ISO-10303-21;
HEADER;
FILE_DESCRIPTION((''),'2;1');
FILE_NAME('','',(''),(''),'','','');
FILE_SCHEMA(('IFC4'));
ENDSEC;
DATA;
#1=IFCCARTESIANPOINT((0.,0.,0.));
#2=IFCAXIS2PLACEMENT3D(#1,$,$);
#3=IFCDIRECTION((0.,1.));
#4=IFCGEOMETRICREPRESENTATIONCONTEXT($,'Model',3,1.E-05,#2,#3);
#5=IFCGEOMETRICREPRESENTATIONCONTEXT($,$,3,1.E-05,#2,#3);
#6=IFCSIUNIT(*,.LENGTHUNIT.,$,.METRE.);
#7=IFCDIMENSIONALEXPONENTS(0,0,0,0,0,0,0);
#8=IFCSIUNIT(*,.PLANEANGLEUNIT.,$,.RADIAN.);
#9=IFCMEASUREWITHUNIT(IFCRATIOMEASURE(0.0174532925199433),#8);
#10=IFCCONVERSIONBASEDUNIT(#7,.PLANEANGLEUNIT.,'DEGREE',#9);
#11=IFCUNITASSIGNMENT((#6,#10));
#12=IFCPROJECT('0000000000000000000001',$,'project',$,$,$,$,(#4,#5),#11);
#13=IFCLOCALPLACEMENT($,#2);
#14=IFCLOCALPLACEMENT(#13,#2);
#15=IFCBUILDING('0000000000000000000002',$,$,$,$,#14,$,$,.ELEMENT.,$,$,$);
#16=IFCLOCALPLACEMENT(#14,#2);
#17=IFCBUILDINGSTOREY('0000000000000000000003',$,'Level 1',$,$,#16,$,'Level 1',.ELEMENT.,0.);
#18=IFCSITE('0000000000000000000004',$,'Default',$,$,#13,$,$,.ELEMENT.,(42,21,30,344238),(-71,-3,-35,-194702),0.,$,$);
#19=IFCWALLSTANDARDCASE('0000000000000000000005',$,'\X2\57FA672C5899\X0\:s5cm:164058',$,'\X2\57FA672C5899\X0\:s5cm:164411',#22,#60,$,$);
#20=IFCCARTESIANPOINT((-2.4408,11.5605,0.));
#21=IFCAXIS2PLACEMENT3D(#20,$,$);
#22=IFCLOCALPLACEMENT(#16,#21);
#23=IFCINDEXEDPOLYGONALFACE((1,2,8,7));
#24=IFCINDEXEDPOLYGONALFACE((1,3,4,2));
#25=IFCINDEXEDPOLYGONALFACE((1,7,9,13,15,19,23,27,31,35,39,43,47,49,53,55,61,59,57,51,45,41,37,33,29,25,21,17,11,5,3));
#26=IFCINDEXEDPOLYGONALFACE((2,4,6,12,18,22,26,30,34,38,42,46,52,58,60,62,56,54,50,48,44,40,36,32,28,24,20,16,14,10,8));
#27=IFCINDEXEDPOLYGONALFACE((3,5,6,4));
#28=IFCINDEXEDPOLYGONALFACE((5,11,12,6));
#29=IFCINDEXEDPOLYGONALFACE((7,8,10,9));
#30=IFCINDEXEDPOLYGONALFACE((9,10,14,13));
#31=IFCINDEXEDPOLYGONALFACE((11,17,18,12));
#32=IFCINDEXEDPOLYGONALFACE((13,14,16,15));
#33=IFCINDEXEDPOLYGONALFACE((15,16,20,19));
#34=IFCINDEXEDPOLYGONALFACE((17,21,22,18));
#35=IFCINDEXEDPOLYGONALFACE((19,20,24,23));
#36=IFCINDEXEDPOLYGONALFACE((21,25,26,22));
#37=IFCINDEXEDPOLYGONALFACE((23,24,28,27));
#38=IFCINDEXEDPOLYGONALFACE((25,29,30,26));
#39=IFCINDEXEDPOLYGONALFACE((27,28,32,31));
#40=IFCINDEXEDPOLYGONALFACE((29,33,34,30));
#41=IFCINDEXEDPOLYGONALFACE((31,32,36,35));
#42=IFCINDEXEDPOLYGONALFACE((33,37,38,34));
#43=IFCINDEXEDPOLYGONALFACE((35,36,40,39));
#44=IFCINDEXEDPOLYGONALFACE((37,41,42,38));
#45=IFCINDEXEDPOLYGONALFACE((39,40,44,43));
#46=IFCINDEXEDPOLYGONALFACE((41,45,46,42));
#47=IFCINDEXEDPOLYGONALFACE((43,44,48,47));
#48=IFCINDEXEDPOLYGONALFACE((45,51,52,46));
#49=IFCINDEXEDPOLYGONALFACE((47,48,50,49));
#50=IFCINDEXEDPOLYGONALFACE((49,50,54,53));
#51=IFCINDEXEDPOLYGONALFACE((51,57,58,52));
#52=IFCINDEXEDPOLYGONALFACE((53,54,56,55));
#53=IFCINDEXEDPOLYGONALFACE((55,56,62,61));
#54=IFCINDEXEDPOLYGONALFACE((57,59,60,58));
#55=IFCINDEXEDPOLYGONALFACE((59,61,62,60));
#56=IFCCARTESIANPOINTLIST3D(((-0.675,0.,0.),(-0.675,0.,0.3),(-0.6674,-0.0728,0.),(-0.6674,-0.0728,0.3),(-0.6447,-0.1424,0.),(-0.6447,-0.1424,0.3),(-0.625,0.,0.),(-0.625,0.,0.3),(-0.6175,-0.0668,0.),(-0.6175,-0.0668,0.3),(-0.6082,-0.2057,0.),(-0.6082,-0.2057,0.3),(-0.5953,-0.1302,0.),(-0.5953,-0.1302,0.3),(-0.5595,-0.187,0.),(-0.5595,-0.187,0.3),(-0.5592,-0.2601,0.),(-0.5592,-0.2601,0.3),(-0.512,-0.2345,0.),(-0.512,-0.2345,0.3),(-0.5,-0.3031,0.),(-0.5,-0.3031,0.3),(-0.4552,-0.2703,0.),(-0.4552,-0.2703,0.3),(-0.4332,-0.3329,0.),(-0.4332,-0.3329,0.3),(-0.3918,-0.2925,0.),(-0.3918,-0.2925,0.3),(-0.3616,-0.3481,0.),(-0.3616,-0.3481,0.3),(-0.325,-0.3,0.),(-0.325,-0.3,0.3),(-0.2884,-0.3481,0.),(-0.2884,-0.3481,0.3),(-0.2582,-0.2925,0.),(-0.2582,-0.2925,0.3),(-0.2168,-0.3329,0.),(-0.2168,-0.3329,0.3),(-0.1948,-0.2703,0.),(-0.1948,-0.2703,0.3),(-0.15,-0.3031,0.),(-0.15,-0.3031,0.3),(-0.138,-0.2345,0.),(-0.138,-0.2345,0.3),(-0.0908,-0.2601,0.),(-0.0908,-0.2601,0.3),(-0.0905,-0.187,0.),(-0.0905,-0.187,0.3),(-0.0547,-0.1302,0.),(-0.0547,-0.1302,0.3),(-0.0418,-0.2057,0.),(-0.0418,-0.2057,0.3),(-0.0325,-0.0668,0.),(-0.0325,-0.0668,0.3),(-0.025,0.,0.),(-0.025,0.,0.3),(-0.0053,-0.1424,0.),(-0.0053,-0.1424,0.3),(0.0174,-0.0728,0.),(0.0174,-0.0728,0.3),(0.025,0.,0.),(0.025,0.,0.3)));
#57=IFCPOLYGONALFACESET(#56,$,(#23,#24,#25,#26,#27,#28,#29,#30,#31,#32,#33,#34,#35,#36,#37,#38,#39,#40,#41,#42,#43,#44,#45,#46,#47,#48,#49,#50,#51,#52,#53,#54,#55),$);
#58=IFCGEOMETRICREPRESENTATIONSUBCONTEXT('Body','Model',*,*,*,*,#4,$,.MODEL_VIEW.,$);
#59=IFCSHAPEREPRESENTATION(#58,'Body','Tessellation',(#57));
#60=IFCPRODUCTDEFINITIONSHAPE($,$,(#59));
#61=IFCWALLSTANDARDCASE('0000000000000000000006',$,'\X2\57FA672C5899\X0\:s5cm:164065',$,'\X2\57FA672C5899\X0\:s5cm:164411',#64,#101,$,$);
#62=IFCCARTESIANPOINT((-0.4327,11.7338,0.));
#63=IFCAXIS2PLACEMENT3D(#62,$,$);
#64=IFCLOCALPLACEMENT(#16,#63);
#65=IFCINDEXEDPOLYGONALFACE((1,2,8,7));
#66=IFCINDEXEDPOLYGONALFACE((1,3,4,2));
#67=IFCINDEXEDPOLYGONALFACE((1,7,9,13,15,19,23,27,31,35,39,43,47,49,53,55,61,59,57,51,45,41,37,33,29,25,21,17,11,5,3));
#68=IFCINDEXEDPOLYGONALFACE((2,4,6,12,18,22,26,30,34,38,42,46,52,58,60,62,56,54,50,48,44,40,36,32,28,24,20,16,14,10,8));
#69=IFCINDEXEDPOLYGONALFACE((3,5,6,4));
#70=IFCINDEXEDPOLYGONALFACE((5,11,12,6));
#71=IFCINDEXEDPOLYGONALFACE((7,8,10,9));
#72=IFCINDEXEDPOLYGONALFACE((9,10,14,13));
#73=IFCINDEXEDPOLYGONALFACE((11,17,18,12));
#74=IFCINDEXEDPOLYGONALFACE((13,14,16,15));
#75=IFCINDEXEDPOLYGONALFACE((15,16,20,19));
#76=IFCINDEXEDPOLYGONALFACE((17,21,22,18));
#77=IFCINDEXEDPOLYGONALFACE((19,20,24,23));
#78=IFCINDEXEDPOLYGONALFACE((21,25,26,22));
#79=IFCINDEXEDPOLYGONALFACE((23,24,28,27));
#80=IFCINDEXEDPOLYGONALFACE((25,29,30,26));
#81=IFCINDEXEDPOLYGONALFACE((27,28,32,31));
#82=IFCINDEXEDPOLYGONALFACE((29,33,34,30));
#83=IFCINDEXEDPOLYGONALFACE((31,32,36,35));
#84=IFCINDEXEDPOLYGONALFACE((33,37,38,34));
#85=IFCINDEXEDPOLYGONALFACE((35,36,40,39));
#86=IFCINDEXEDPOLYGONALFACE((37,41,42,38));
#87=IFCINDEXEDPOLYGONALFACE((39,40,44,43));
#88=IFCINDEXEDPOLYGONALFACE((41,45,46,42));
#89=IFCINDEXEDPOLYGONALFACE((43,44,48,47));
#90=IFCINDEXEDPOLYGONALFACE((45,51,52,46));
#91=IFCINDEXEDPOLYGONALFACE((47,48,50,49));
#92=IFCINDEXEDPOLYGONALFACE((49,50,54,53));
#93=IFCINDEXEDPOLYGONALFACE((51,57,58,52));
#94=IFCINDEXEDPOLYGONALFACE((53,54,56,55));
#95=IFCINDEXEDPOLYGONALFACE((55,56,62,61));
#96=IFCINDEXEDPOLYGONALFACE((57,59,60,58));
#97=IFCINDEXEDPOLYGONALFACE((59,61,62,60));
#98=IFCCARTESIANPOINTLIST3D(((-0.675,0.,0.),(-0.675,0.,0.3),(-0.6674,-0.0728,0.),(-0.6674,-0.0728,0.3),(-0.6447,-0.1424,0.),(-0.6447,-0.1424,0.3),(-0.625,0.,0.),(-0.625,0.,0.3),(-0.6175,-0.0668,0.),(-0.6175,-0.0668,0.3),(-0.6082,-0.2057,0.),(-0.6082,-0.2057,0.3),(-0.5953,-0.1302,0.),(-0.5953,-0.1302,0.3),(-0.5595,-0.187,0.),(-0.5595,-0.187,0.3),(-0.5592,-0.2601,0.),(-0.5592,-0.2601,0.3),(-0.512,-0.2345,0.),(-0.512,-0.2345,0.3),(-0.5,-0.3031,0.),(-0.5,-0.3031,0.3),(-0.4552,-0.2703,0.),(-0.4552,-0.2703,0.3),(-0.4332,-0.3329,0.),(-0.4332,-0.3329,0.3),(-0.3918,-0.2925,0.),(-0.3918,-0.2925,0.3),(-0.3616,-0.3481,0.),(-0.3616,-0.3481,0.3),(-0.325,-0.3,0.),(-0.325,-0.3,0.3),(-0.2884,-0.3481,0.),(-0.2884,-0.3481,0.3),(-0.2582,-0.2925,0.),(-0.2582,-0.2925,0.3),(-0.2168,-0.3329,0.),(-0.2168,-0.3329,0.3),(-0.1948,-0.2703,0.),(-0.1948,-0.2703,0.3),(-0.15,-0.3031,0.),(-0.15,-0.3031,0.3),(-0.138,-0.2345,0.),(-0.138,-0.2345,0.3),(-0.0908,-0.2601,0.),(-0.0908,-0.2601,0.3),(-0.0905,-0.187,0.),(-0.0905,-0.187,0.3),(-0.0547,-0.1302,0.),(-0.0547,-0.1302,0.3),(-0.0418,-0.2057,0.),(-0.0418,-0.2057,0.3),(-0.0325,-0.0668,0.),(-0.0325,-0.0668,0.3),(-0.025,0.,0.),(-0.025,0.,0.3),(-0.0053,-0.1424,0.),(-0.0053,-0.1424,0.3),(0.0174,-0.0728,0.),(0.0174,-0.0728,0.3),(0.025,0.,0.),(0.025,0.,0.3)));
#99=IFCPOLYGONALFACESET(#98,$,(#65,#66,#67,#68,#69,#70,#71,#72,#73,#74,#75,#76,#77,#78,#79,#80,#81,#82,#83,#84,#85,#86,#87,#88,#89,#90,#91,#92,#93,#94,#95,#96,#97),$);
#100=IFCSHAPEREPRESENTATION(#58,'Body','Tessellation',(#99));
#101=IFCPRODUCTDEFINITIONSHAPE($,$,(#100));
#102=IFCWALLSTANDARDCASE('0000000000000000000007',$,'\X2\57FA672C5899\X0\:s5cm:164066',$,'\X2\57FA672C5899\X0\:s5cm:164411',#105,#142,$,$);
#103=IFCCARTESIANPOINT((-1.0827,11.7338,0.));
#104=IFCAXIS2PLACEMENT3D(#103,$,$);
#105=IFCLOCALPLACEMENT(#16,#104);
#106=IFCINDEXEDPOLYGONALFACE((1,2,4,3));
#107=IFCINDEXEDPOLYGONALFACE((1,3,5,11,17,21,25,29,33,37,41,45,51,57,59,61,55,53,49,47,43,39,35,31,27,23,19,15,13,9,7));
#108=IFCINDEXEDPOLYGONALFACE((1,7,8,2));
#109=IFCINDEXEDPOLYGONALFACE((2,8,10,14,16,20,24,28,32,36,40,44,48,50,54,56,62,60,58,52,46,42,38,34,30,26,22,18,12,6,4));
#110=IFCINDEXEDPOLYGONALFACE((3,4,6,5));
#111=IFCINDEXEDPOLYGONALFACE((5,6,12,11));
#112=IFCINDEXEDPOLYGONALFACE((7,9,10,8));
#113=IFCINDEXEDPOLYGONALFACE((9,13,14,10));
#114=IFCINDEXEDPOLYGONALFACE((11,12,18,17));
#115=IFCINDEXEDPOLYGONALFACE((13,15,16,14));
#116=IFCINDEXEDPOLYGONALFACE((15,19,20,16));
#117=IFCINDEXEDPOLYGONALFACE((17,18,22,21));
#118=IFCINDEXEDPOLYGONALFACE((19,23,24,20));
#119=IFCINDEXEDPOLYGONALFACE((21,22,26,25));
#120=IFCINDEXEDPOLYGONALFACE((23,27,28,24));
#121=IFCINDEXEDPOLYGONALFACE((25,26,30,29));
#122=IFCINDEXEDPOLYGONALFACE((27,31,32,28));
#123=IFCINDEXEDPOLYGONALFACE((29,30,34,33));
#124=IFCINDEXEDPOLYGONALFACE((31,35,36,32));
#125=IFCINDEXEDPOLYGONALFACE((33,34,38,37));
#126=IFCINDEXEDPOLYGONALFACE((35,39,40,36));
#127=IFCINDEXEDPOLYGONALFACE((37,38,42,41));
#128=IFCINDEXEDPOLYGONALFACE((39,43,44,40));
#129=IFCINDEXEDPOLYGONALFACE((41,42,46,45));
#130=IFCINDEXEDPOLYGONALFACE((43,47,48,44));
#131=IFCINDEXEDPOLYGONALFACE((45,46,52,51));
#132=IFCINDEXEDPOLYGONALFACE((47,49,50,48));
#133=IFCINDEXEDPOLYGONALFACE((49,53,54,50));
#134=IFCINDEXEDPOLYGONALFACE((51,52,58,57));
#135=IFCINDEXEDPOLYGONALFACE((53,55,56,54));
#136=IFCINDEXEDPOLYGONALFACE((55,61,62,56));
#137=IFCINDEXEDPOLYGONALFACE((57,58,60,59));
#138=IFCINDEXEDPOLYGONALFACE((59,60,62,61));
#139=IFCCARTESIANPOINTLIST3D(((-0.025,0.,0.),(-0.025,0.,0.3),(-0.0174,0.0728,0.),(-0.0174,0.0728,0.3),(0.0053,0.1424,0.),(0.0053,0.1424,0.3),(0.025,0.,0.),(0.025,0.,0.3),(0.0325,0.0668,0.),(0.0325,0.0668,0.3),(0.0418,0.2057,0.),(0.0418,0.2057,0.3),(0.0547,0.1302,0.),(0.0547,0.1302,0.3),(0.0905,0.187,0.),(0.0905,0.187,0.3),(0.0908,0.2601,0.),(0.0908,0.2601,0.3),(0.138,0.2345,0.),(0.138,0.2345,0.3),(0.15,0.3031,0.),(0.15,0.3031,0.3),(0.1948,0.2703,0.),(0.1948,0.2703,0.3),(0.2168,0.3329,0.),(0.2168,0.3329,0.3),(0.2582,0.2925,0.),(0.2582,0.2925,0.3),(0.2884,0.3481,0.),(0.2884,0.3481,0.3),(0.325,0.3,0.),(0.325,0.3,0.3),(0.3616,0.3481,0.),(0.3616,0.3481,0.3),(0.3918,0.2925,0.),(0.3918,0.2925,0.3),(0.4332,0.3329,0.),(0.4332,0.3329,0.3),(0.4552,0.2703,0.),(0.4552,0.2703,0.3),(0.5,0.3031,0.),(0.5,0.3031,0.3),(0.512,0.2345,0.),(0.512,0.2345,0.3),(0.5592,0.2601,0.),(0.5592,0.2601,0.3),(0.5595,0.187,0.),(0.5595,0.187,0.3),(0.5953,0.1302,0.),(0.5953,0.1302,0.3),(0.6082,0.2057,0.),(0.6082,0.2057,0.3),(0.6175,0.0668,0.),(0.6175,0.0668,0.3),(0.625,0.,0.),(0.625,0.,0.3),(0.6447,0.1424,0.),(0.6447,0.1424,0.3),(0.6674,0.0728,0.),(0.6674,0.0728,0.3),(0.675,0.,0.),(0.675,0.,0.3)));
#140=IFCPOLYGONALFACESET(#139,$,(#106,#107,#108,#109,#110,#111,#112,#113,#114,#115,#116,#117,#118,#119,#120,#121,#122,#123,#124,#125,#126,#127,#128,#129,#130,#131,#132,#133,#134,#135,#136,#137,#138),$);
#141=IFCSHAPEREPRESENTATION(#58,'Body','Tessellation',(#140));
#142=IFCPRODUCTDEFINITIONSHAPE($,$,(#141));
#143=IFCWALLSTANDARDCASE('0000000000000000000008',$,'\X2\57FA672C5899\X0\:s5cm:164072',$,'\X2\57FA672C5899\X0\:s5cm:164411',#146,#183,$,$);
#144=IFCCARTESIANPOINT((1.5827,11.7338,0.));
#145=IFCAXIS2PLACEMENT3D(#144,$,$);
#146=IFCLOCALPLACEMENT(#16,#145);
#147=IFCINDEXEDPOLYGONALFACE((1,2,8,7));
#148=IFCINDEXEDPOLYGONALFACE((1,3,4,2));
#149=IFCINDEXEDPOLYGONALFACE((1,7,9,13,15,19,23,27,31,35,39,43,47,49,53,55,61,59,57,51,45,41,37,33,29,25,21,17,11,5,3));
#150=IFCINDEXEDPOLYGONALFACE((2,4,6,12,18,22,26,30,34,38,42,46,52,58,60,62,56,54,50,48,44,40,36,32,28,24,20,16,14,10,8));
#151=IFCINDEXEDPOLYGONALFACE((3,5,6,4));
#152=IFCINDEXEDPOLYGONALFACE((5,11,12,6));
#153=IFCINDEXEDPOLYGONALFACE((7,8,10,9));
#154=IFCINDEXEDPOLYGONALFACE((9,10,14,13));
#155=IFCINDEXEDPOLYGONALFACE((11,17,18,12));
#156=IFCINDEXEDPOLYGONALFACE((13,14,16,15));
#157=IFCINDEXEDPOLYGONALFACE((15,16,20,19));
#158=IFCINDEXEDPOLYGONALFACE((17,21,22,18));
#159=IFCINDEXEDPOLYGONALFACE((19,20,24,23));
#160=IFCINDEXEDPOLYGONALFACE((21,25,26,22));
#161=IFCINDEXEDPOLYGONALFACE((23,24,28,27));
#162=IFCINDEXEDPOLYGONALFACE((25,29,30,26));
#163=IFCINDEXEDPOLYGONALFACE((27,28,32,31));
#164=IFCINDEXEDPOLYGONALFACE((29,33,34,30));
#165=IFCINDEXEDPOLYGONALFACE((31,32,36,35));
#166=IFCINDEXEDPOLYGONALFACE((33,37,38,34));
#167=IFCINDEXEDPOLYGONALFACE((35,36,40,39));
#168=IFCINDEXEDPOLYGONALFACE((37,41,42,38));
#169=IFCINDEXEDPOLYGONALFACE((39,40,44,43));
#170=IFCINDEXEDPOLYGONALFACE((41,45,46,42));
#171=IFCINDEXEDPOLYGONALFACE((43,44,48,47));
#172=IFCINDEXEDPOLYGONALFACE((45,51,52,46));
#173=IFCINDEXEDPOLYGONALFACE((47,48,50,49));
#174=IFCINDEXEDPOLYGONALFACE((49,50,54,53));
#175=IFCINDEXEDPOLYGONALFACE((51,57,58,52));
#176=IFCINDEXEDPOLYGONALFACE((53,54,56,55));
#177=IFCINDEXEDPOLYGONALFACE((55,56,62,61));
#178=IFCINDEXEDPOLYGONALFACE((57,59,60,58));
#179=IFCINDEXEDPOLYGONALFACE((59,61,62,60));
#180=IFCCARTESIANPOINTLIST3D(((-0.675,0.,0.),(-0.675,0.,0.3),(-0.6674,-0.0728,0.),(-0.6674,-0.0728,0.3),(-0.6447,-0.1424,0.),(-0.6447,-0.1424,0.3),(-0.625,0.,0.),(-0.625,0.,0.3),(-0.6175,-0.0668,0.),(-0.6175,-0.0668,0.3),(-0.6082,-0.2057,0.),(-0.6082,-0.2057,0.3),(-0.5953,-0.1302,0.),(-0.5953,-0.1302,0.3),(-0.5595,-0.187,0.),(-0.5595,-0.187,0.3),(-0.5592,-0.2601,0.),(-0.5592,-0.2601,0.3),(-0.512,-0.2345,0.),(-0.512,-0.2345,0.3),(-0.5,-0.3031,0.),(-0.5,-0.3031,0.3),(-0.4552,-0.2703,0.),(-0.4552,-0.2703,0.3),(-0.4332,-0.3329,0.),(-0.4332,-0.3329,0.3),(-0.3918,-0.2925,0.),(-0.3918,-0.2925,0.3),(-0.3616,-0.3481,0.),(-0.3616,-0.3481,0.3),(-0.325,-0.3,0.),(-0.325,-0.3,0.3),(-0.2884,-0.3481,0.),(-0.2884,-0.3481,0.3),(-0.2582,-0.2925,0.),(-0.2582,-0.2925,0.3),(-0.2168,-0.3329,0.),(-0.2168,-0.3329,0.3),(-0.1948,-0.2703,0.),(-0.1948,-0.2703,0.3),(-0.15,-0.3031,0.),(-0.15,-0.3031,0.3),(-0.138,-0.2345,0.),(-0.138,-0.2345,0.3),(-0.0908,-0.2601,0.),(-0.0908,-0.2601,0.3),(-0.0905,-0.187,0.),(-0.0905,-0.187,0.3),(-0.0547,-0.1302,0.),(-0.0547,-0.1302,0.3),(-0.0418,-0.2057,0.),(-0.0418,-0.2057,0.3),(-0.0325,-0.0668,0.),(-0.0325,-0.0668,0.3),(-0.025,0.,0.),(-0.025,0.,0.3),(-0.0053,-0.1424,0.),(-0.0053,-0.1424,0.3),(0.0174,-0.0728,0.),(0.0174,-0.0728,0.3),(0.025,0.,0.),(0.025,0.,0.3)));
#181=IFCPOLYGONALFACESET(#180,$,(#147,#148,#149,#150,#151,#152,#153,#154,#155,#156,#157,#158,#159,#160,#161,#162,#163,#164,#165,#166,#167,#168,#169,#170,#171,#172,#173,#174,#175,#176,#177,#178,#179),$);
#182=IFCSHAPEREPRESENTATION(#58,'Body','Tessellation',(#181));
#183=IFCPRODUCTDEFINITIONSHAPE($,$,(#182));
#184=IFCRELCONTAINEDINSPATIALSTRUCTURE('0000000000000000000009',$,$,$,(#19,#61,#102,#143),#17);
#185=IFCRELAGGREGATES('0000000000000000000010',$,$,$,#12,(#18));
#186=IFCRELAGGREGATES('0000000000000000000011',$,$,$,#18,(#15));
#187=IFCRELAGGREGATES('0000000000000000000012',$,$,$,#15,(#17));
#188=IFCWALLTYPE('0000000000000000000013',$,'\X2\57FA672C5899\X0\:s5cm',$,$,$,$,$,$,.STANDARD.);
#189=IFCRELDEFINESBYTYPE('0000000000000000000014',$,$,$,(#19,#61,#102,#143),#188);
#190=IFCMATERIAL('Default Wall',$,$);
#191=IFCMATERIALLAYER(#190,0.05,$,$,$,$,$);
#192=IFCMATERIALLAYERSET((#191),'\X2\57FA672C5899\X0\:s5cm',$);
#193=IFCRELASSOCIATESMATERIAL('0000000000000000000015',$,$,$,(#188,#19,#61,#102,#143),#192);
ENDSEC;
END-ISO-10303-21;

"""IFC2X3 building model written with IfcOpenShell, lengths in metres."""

from ifc_helpers import new_model, entity, si_unit, converted_unit, direction, frame, frame_2d, origin, place, context, subcontext, project, spatial, polyline, circle_curve, parameter, trimmed, segment, composite_curve, outline, extrude, material, layer, layer_set, layer_usage, type_object, element, save


model = new_model("IFC2X3")

# Units and contexts
model_context = context("Model", 3, precision=1e-05, world=origin(), true_north=direction((0.0, 1.0)))
context_of_model = context(None, 3, precision=1e-05, world=origin(), true_north=direction((0.0, 1.0)))
body_context = subcontext(model_context, "Body", "Model", "MODEL_VIEW")
ifc_project = project(units=[si_unit("LENGTHUNIT", "METRE"), converted_unit("PLANEANGLEUNIT", "DEGREE", entity("IfcRatioMeasure", 0.0174532925199433), si_unit("PLANEANGLEUNIT", "RADIAN"), dimensions=[0, 0, 0, 0, 0, 0, 0])], contexts=[model_context, context_of_model])

# Site, building, storey
site_placement = place(None, origin())
site = spatial("IfcSite", under=ifc_project, at=site_placement, Name="Default", CompositionType="ELEMENT", RefLatitude=(42, 21, 30, 344238), RefLongitude=(-71, -3, -35, -194702), RefElevation=0.0)
building_placement = place(site_placement, origin())
building = spatial("IfcBuilding", under=site, at=building_placement, CompositionType="ELEMENT")
storey_placement = place(building_placement, origin())
storey = spatial("IfcBuildingStorey", under=building, at=storey_placement, Name="Level 1", LongName="Level 1", CompositionType="ELEMENT", Elevation=0.0)

# Shared definitions
ifc_material_1 = material(Name="Default Wall")

# Walls
ifc_layer_1 = layer(ifc_material_1, 0.05)
ifc_layer_set_1 = layer_set([ifc_layer_1], Name="基本墙:s5cm")
wall_type_1 = type_object("IfcWallType", Name="基本墙:s5cm", PredefinedType="STANDARD", material=ifc_layer_set_1)
ifc_layer_usage_1 = layer_usage(ifc_layer_set_1, "AXIS2", "POSITIVE", -0.025)
wall_1_placement = place(storey_placement, frame((-2.4408, 11.5605, 0.0)))
element("IfcWallStandardCase", 1, at=wall_1_placement, inside=storey, type_object=wall_type_1, material=ifc_layer_usage_1, Name="基本墙:s5cm:164058", ObjectType="基本墙:s5cm:164411", context=body_context, shape_type="SweptSolid", body=[
    extrude(outline(composite_curve([segment(trimmed(circle_curve(frame_2d((-0.325, 0.0), x_axis=(1.0, 0.0)), 0.35), [parameter(180.0)], [parameter(0.0)], True, "PARAMETER"), True, "CONTINUOUS"), segment(polyline([(0.025, 0.0), (-0.025, 0.0)]), True, "CONTINUOUS"), segment(trimmed(circle_curve(frame_2d((-0.325, 0.0), x_axis=(1.0, 0.0)), 0.3), [parameter(180.0)], [parameter(0.0)], True, "PARAMETER"), False, "CONTINUOUS"), segment(polyline([(-0.625, 0.0), (-0.675, 0.0)]), True, "CONTINUOUS")], self_intersect=False)), origin(), (0.0, 0.0, 1.0), 0.3),
])
ifc_layer_usage_2 = layer_usage(ifc_layer_set_1, "AXIS2", "POSITIVE", -0.025)
wall_2_placement = place(storey_placement, frame((-0.4327, 11.7338, 0.0)))
element("IfcWallStandardCase", 2, at=wall_2_placement, inside=storey, type_object=wall_type_1, material=ifc_layer_usage_2, Name="基本墙:s5cm:164065", ObjectType="基本墙:s5cm:164411", context=body_context, shape_type="SweptSolid", body=[
    extrude(outline(composite_curve([segment(trimmed(circle_curve(frame_2d((-0.325, 0.0), x_axis=(1.0, 0.0)), 0.35), [parameter(180.0)], [parameter(0.0)], True, "PARAMETER"), True, "CONTINUOUS"), segment(polyline([(0.025, 0.0), (-0.025, 0.0)]), True, "CONTINUOUS"), segment(trimmed(circle_curve(frame_2d((-0.325, 0.0), x_axis=(1.0, 0.0)), 0.3), [parameter(180.0)], [parameter(0.0)], True, "PARAMETER"), False, "CONTINUOUS"), segment(polyline([(-0.625, 0.0), (-0.675, 0.0)]), True, "CONTINUOUS")], self_intersect=False)), origin(), (0.0, 0.0, 1.0), 0.3),
])
ifc_layer_usage_3 = layer_usage(ifc_layer_set_1, "AXIS2", "POSITIVE", -0.025)
wall_3_placement = place(storey_placement, frame((-1.0827, 11.7338, 0.0)))
element("IfcWallStandardCase", 3, at=wall_3_placement, inside=storey, type_object=wall_type_1, material=ifc_layer_usage_3, Name="基本墙:s5cm:164066", ObjectType="基本墙:s5cm:164411", context=body_context, shape_type="SweptSolid", body=[
    extrude(outline(composite_curve([segment(trimmed(circle_curve(frame_2d((0.325, 0.0), x_axis=(1.0, 0.0)), 0.35), [parameter(0.0)], [parameter(180.0)], True, "PARAMETER"), True, "CONTINUOUS"), segment(polyline([(-0.025, 0.0), (0.025, 0.0)]), True, "CONTINUOUS"), segment(trimmed(circle_curve(frame_2d((0.325, 0.0), x_axis=(1.0, 0.0)), 0.3), [parameter(0.0)], [parameter(180.0)], True, "PARAMETER"), False, "CONTINUOUS"), segment(polyline([(0.625, 0.0), (0.675, 0.0)]), True, "CONTINUOUS")], self_intersect=False)), origin(), (0.0, 0.0, 1.0), 0.3),
])
ifc_layer_usage_4 = layer_usage(ifc_layer_set_1, "AXIS2", "POSITIVE", -0.025)
wall_4_placement = place(storey_placement, frame((1.5827, 11.7338, 0.0)))
element("IfcWallStandardCase", 4, at=wall_4_placement, inside=storey, type_object=wall_type_1, material=ifc_layer_usage_4, Name="基本墙:s5cm:164072", ObjectType="基本墙:s5cm:164411", context=body_context, shape_type="SweptSolid", body=[
    extrude(outline(composite_curve([segment(trimmed(circle_curve(frame_2d((-0.325, 0.0), x_axis=(1.0, 0.0)), 0.35), [parameter(180.0)], [parameter(0.0)], True, "PARAMETER"), True, "CONTINUOUS"), segment(polyline([(0.025, 0.0), (-0.025, 0.0)]), True, "CONTINUOUS"), segment(trimmed(circle_curve(frame_2d((-0.325, 0.0), x_axis=(1.0, 0.0)), 0.3), [parameter(180.0)], [parameter(0.0)], True, "PARAMETER"), False, "CONTINUOUS"), segment(polyline([(-0.625, 0.0), (-0.675, 0.0)]), True, "CONTINUOUS")], self_intersect=False)), origin(), (0.0, 0.0, 1.0), 0.3),
])

save(model, "model.ifc")
